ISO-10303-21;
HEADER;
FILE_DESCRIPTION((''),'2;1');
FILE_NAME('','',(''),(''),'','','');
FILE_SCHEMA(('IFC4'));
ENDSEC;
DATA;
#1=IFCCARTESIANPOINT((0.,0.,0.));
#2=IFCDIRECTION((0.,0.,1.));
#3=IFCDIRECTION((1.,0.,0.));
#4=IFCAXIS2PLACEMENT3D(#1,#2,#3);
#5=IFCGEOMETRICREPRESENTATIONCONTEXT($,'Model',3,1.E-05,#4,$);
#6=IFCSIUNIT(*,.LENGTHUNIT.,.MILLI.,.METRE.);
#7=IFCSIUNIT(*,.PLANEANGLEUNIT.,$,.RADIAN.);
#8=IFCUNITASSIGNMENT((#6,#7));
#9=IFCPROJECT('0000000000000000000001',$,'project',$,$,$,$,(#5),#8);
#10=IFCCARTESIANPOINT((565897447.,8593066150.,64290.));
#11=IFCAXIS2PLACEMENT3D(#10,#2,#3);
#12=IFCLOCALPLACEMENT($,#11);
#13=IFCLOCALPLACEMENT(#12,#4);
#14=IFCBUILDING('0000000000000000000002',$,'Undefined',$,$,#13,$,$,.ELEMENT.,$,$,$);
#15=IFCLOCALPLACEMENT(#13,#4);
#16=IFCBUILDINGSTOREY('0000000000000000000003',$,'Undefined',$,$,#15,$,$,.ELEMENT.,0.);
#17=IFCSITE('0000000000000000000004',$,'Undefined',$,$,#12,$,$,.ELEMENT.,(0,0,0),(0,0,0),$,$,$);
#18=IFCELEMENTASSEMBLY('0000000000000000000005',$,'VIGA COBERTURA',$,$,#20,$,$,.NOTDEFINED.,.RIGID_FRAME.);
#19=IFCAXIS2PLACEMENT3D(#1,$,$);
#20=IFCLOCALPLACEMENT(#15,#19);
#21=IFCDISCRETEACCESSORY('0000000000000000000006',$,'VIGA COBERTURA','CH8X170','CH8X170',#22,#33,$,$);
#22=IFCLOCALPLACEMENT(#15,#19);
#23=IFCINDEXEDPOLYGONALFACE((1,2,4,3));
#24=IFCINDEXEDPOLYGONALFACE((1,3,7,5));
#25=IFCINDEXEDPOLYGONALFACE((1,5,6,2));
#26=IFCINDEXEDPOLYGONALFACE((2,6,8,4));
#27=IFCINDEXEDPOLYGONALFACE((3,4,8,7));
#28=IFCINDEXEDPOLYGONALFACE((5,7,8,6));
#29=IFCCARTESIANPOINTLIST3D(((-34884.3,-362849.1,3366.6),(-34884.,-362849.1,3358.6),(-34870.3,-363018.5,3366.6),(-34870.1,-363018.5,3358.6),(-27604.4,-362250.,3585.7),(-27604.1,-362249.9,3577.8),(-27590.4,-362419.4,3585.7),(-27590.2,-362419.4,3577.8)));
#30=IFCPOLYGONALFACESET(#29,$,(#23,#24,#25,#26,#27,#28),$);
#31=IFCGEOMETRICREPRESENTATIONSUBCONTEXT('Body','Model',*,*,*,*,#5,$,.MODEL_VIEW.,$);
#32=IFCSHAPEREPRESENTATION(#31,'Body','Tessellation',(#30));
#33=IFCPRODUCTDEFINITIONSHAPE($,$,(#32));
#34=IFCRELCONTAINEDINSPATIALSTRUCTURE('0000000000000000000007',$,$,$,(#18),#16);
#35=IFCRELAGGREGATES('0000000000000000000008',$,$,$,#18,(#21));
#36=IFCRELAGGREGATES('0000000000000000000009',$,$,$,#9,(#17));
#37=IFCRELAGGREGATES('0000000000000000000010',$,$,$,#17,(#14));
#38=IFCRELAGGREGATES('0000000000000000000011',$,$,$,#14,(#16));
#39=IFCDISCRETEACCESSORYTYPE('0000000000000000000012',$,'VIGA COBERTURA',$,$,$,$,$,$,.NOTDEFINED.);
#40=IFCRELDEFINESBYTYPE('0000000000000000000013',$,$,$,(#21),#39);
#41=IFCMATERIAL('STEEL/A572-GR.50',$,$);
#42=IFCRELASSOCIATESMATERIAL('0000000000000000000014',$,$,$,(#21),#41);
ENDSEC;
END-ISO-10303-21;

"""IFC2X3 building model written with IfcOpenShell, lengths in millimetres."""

from ifc_helpers import new_model, si_unit, frame, origin_with_axes, place, context, subcontext, project, spatial, polyline, outline, extrude, material, type_object, element, aggregate, save


model = new_model("IFC2X3")

# Units and contexts
model_context = context("Model", 3, precision=1e-05, world=origin_with_axes())
body_context = subcontext(model_context, "Body", "Model", "MODEL_VIEW")
ifc_project = project(units=[si_unit("LENGTHUNIT", "METRE", prefix="MILLI"), si_unit("PLANEANGLEUNIT", "RADIAN")], contexts=[model_context])

# Site, building, storey
site_placement = place(None, frame((565897447.0, 8593066150.0, 64290.0), z_axis=(0.0, 0.0, 1.0), x_axis=(1.0, 0.0, 0.0)))
site = spatial("IfcSite", under=ifc_project, at=site_placement, Name="Undefined", CompositionType="ELEMENT", RefLatitude=(0, 0, 0), RefLongitude=(0, 0, 0))
building_placement = place(site_placement, origin_with_axes())
building = spatial("IfcBuilding", under=site, at=building_placement, Name="Undefined", CompositionType="ELEMENT")
storey_placement = place(building_placement, origin_with_axes())
storey = spatial("IfcBuildingStorey", under=building, at=storey_placement, Name="Undefined", CompositionType="ELEMENT", Elevation=0.0)

# Element assembly
assembly_1_placement = place(storey_placement, origin_with_axes())
assembly_1 = element("IfcElementAssembly", 1, at=assembly_1_placement, inside=storey, Name="VIGA COBERTURA", AssemblyPlace="NOTDEFINED", PredefinedType="RIGID_FRAME")
ifc_material_1 = material(Name="STEEL/A572-GR.50")
discrete_accessory_type_1 = type_object("IfcDiscreteAccessoryType", Name="VIGA COBERTURA")

# Discrete accessory
discrete_accessory_1_placement = place(assembly_1_placement, frame((-27597.3, -362334.7, 3581.7), z_axis=(0.029885, 0.00246, -0.99955), x_axis=(-0.996182, -0.081989, -0.029987)))
discrete_accessory_1 = element("IfcDiscreteAccessory", 2, at=discrete_accessory_1_placement, type_object=discrete_accessory_type_1, material=ifc_material_1, Name="VIGA COBERTURA", Description="CH8X170", ObjectType="CH8X170", context=body_context, shape_type="SweptSolid", body=[
    extrude(outline(polyline([(7307.8, 85.0), (7307.8, -85.0), (0.0, -85.0), (0.0, 85.0), (7307.8, 85.0)])), frame((0.0, 0.0, -4.0), z_axis=(0.0, 0.0, 1.0), x_axis=(1.0, 0.0, 0.0)), (0.0, 0.0, 1.0), 8.0),
])
aggregate(assembly_1, [discrete_accessory_1])

save(model, "model.ifc")
